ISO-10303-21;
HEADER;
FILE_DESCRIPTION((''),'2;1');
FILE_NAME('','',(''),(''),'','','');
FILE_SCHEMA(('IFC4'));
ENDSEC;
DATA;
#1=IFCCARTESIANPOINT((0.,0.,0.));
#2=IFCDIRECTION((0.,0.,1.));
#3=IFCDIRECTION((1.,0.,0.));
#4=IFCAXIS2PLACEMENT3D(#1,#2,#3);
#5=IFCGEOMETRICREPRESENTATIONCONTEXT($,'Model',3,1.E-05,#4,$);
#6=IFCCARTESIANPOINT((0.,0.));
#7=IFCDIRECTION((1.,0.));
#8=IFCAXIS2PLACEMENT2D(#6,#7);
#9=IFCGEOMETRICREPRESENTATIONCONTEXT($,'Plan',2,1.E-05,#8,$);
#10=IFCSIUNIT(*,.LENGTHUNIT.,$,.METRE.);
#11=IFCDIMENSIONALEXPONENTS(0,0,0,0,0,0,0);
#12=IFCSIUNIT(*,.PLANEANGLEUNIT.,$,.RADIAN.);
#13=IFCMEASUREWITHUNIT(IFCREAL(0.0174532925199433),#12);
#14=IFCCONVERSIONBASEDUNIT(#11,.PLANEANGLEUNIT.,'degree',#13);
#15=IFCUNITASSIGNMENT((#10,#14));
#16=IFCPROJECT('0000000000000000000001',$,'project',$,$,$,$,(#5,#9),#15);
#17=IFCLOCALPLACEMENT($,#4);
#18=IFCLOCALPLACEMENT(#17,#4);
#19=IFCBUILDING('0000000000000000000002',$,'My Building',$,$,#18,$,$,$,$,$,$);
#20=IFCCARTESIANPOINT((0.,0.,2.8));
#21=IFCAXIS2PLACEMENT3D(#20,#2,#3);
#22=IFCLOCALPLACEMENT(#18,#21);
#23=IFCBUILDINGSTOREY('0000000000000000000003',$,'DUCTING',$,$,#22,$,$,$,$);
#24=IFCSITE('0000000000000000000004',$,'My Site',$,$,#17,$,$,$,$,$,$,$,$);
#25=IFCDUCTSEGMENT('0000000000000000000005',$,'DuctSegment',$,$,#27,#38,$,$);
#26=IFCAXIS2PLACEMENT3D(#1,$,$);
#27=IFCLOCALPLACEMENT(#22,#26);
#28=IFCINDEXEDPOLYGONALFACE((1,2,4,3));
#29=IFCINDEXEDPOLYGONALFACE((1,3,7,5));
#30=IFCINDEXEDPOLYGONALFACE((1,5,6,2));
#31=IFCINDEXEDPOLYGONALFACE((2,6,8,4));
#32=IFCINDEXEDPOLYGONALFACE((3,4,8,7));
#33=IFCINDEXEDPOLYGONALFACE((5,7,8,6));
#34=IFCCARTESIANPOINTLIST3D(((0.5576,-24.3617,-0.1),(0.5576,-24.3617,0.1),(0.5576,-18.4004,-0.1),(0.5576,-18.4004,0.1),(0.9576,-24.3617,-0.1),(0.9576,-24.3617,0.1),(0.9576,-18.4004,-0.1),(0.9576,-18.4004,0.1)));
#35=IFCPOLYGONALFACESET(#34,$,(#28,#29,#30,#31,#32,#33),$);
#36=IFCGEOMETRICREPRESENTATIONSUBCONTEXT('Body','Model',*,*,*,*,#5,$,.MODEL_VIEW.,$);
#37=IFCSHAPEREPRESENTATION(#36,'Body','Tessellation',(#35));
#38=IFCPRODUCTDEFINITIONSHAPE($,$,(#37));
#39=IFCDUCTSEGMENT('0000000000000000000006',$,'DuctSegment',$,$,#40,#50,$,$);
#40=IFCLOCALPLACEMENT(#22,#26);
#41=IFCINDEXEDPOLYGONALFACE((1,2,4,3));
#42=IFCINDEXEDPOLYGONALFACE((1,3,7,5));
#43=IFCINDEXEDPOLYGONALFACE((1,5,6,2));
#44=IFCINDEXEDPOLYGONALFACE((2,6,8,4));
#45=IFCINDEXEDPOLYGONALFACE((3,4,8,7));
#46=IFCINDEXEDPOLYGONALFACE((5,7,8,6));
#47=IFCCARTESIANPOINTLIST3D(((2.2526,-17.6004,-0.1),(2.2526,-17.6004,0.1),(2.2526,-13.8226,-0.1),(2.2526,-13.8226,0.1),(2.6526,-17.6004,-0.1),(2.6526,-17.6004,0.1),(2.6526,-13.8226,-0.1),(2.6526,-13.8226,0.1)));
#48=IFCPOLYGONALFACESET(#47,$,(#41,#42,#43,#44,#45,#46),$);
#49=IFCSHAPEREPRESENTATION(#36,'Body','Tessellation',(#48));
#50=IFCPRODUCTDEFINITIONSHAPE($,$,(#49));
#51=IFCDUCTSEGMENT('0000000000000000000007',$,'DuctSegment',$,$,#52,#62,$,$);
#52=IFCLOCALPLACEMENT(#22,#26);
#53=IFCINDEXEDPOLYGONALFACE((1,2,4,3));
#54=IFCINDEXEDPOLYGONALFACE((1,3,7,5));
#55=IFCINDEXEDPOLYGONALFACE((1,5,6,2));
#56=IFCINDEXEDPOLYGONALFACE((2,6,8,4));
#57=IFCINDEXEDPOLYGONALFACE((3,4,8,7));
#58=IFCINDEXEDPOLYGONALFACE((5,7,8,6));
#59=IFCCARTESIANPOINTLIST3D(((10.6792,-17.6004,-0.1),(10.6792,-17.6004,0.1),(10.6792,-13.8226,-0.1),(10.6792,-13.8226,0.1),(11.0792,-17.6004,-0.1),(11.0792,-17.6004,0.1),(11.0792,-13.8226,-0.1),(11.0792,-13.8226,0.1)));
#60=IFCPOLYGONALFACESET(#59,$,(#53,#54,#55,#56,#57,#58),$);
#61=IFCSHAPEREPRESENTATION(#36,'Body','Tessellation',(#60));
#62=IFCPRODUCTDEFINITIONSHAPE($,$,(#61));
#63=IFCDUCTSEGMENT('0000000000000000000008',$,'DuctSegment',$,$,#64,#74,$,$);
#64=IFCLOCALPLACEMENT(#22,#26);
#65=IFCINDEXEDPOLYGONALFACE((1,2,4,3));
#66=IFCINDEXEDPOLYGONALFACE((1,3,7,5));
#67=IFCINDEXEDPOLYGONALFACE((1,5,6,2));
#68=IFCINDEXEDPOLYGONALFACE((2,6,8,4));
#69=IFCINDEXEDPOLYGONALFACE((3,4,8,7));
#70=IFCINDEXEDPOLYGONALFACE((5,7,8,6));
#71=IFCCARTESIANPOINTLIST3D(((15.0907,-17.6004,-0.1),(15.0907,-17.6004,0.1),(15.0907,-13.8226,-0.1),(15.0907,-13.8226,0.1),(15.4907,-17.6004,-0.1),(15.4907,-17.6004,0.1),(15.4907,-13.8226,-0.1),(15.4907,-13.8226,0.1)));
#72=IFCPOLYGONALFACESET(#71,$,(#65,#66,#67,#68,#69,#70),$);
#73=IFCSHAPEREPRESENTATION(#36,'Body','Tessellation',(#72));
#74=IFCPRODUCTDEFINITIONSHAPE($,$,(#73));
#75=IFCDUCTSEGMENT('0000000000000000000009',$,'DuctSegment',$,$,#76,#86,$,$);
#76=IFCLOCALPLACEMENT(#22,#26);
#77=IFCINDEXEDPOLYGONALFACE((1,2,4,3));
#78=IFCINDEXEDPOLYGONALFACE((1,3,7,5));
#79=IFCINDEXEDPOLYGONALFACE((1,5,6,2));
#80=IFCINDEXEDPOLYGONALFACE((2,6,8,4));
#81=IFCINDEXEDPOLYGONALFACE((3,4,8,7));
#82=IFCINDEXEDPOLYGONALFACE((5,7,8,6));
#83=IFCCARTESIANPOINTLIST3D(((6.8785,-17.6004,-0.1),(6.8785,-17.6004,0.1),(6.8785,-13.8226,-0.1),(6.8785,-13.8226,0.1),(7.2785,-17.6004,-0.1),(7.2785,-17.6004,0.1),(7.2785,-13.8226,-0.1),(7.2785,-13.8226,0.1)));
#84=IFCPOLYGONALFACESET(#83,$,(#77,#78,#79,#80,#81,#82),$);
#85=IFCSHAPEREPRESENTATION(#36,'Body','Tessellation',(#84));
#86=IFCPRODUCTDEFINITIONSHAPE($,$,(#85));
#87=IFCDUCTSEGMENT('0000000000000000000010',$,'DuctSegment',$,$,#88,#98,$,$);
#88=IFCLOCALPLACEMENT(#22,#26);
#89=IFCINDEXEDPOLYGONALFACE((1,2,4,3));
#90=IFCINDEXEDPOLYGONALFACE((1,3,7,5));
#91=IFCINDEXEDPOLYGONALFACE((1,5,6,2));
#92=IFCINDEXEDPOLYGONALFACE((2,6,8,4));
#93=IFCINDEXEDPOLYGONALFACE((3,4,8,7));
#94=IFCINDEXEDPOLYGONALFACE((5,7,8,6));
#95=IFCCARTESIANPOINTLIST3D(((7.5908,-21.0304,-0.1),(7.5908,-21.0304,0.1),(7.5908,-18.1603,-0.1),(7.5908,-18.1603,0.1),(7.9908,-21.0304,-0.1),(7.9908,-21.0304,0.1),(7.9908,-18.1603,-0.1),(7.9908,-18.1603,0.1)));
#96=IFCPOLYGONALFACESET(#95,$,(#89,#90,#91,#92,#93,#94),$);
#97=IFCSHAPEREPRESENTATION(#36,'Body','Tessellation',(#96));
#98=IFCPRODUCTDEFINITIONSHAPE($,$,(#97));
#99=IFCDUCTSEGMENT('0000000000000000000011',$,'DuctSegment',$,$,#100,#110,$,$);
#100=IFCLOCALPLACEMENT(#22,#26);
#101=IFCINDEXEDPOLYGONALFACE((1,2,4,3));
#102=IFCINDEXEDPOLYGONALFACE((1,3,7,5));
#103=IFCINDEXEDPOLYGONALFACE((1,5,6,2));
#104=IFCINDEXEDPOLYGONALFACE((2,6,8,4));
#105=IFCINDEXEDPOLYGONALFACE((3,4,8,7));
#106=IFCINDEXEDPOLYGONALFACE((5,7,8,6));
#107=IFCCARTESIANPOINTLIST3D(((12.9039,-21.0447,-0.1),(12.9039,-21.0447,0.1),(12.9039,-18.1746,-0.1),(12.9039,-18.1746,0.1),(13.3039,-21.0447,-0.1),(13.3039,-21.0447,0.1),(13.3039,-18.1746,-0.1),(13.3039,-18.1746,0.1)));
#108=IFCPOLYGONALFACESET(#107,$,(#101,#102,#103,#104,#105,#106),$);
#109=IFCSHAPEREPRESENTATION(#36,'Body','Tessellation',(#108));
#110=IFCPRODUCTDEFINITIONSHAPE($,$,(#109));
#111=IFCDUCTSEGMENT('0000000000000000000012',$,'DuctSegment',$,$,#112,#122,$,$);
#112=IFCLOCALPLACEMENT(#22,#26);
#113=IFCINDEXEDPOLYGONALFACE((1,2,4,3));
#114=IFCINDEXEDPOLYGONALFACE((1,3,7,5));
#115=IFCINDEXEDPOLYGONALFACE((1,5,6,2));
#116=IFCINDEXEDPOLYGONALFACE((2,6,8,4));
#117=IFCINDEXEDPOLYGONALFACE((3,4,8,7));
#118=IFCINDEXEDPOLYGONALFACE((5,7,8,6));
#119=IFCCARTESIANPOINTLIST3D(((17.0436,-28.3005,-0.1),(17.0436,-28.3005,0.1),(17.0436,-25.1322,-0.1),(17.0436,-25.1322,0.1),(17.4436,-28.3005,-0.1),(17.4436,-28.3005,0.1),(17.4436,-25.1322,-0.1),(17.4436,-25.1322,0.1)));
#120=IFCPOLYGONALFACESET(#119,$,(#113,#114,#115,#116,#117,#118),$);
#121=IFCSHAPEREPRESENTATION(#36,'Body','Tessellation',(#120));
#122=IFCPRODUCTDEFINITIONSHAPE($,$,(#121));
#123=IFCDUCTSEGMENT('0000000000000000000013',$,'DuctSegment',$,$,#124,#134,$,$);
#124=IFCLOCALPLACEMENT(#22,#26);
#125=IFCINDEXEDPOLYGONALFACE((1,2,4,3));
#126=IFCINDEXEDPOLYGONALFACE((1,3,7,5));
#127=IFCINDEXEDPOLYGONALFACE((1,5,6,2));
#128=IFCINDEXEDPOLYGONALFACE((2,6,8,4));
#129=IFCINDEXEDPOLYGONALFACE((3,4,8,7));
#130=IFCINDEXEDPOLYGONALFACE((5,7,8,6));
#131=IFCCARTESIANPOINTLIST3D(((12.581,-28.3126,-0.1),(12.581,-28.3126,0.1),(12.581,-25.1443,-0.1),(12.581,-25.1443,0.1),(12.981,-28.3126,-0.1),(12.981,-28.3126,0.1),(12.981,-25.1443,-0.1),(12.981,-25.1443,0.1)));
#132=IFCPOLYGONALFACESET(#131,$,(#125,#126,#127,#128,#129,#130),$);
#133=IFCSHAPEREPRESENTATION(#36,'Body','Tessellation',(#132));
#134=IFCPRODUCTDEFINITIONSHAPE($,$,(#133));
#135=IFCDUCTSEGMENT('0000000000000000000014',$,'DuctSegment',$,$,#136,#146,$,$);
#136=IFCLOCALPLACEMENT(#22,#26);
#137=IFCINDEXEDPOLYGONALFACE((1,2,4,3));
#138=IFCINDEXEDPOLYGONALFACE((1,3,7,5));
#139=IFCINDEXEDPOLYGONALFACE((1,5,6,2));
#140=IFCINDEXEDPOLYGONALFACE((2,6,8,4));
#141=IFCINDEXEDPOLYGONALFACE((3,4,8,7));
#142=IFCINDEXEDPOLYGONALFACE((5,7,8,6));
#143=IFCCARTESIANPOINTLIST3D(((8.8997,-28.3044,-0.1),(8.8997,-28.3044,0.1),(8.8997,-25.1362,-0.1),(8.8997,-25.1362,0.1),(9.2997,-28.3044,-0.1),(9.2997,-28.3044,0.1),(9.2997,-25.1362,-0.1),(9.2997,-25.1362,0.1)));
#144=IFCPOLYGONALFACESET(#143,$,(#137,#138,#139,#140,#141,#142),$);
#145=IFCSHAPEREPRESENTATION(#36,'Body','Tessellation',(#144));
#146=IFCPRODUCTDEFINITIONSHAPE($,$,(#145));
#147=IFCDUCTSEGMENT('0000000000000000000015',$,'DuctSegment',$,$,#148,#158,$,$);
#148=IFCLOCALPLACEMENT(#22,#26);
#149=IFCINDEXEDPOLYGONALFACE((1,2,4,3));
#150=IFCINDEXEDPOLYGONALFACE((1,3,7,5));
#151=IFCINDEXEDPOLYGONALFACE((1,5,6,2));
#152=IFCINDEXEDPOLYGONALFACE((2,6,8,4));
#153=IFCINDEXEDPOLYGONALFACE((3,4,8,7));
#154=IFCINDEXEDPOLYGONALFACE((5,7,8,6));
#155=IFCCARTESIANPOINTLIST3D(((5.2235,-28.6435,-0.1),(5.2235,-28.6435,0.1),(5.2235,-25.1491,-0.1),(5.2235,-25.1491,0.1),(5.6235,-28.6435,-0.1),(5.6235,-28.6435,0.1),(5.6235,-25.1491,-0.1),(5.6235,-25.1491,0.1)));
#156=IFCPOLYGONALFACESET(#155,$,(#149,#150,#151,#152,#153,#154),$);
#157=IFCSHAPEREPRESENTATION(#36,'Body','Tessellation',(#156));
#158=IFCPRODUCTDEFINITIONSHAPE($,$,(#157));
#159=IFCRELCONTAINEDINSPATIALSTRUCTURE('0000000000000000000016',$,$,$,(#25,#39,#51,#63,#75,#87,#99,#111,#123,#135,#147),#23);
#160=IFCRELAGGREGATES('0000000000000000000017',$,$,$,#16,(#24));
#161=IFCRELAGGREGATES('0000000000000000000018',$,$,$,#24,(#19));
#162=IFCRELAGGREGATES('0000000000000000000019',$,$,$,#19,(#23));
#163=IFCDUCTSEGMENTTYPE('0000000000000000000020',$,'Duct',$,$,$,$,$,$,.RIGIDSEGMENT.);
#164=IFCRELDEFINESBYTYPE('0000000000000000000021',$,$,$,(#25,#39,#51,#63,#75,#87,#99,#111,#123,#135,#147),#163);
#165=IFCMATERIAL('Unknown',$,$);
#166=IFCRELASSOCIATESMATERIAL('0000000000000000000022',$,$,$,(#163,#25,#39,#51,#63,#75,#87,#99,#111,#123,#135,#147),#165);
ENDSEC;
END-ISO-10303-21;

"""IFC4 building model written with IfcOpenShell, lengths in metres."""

from ifc_helpers import new_model, entity, si_unit, converted_unit, frame, origin_with_axes, origin_2d_with_axis, place, context, subcontext, project, spatial, rectangle, extrude, material, material_profile, profile_set, profile_usage, type_object, element, save


model = new_model("IFC4")

# Units and contexts
model_context = context("Model", 3, precision=1e-05, world=origin_with_axes())
plan_context = context("Plan", 2, precision=1e-05, world=origin_2d_with_axis())
body_context = subcontext(model_context, "Body", "Model", "MODEL_VIEW")
ifc_project = project(units=[si_unit("LENGTHUNIT", "METRE"), converted_unit("PLANEANGLEUNIT", "degree", entity("IfcReal", 0.0174532925199433), si_unit("PLANEANGLEUNIT", "RADIAN"), dimensions=[0, 0, 0, 0, 0, 0, 0])], contexts=[model_context, plan_context])

# Site, building, storey
site_placement = place(None, origin_with_axes())
site = spatial("IfcSite", under=ifc_project, at=site_placement, Name="My Site")
building_placement = place(site_placement, origin_with_axes())
building = spatial("IfcBuilding", under=site, at=building_placement, Name="My Building")
storey_placement = place(building_placement, frame((0.0, 0.0, 2.8), z_axis=(0.0, 0.0, 1.0), x_axis=(1.0, 0.0, 0.0)))
storey = spatial("IfcBuildingStorey", under=building, at=storey_placement, Name="DUCTING")

# Duct segments
ifc_material = material(Name="Unknown")
ifc_material_profile_1 = material_profile(ifc_material, rectangle(XDim=0.4, YDim=0.2))
ifc_profile_set_1 = profile_set([ifc_material_profile_1])
ifc_profile_usage_1 = profile_usage(ifc_profile_set_1, cardinal=5)
duct_segment_type = type_object("IfcDuctSegmentType", Name="Duct", PredefinedType="RIGIDSEGMENT", material=ifc_profile_set_1)
duct_segment_1_placement = place(storey_placement, frame((0.7576, -24.3617, 0.0), z_axis=(0.0, 1.0, 0.0), x_axis=(-1.0, 0.0, 0.0)))
element("IfcDuctSegment", 1, at=duct_segment_1_placement, inside=storey, type_object=duct_segment_type, material=ifc_profile_usage_1, Name="DuctSegment", context=body_context, shape_type="SweptSolid", body=[
    extrude(rectangle(XDim=0.4, YDim=0.2), origin_with_axes(), (0.0, 0.0, 1.0), 5.9613),
])
ifc_profile_usage_2 = profile_usage(ifc_profile_set_1, cardinal=5)
duct_segment_2_placement = place(storey_placement, frame((2.4526, -17.6004, 0.0), z_axis=(0.0, 1.0, 0.0), x_axis=(-1.0, 0.0, 0.0)))
element("IfcDuctSegment", 2, at=duct_segment_2_placement, inside=storey, type_object=duct_segment_type, material=ifc_profile_usage_2, Name="DuctSegment", context=body_context, shape_type="SweptSolid", body=[
    extrude(rectangle(XDim=0.4, YDim=0.2), origin_with_axes(), (0.0, 0.0, 1.0), 3.7777),
])
ifc_profile_usage_3 = profile_usage(ifc_profile_set_1, cardinal=5)
duct_segment_3_placement = place(storey_placement, frame((10.8792, -17.6004, 0.0), z_axis=(0.0, 1.0, 0.0), x_axis=(-1.0, 0.0, 0.0)))
element("IfcDuctSegment", 3, at=duct_segment_3_placement, inside=storey, type_object=duct_segment_type, material=ifc_profile_usage_3, Name="DuctSegment", context=body_context, shape_type="SweptSolid", body=[
    extrude(rectangle(XDim=0.4, YDim=0.2), origin_with_axes(), (0.0, 0.0, 1.0), 3.7777),
])
ifc_profile_usage_4 = profile_usage(ifc_profile_set_1, cardinal=5)
duct_segment_4_placement = place(storey_placement, frame((15.2907, -17.6004, 0.0), z_axis=(0.0, 1.0, 0.0), x_axis=(-1.0, 0.0, 0.0)))
element("IfcDuctSegment", 4, at=duct_segment_4_placement, inside=storey, type_object=duct_segment_type, material=ifc_profile_usage_4, Name="DuctSegment", context=body_context, shape_type="SweptSolid", body=[
    extrude(rectangle(XDim=0.4, YDim=0.2), origin_with_axes(), (0.0, 0.0, 1.0), 3.7777),
])
ifc_profile_usage_5 = profile_usage(ifc_profile_set_1, cardinal=5)
duct_segment_5_placement = place(storey_placement, frame((7.0785, -13.8226, 0.0), z_axis=(0.0, -1.0, 0.0), x_axis=(1.0, 0.0, 0.0)))
element("IfcDuctSegment", 5, at=duct_segment_5_placement, inside=storey, type_object=duct_segment_type, material=ifc_profile_usage_5, Name="DuctSegment", context=body_context, shape_type="SweptSolid", body=[
    extrude(rectangle(XDim=0.4, YDim=0.2), origin_with_axes(), (0.0, 0.0, 1.0), 3.7777),
])
ifc_profile_usage_6 = profile_usage(ifc_profile_set_1, cardinal=5)
duct_segment_6_placement = place(storey_placement, frame((7.7908, -21.0304, 0.0), z_axis=(-0.000001, 1.0, 0.0), x_axis=(-1.0, -0.000001, 0.0)))
element("IfcDuctSegment", 6, at=duct_segment_6_placement, inside=storey, type_object=duct_segment_type, material=ifc_profile_usage_6, Name="DuctSegment", context=body_context, shape_type="SweptSolid", body=[
    extrude(rectangle(XDim=0.4, YDim=0.2), origin_with_axes(), (0.0, 0.0, 1.0), 2.8701),
])
ifc_profile_usage_7 = profile_usage(ifc_profile_set_1, cardinal=5)
duct_segment_7_placement = place(storey_placement, frame((13.1039, -21.0447, 0.0), z_axis=(-0.000001, 1.0, 0.0), x_axis=(-1.0, -0.000001, 0.0)))
element("IfcDuctSegment", 7, at=duct_segment_7_placement, inside=storey, type_object=duct_segment_type, material=ifc_profile_usage_7, Name="DuctSegment", context=body_context, shape_type="SweptSolid", body=[
    extrude(rectangle(XDim=0.4, YDim=0.2), origin_with_axes(), (0.0, 0.0, 1.0), 2.8701),
])
ifc_profile_usage_8 = profile_usage(ifc_profile_set_1, cardinal=5)
duct_segment_8_placement = place(storey_placement, frame((17.2436, -28.3005, 0.0), z_axis=(0.0, 1.0, 0.0), x_axis=(-1.0, 0.0, 0.0)))
element("IfcDuctSegment", 8, at=duct_segment_8_placement, inside=storey, type_object=duct_segment_type, material=ifc_profile_usage_8, Name="DuctSegment", context=body_context, shape_type="SweptSolid", body=[
    extrude(rectangle(XDim=0.4, YDim=0.2), origin_with_axes(), (0.0, 0.0, 1.0), 3.1683),
])
ifc_profile_usage_9 = profile_usage(ifc_profile_set_1, cardinal=5)
duct_segment_9_placement = place(storey_placement, frame((12.781, -28.3126, 0.0), z_axis=(0.0, 1.0, 0.0), x_axis=(-1.0, 0.0, 0.0)))
element("IfcDuctSegment", 9, at=duct_segment_9_placement, inside=storey, type_object=duct_segment_type, material=ifc_profile_usage_9, Name="DuctSegment", context=body_context, shape_type="SweptSolid", body=[
    extrude(rectangle(XDim=0.4, YDim=0.2), origin_with_axes(), (0.0, 0.0, 1.0), 3.1683),
])
ifc_profile_usage_10 = profile_usage(ifc_profile_set_1, cardinal=5)
duct_segment_10_placement = place(storey_placement, frame((9.0997, -28.3044, 0.0), z_axis=(0.0, 1.0, 0.0), x_axis=(-1.0, 0.0, 0.0)))
element("IfcDuctSegment", 10, at=duct_segment_10_placement, inside=storey, type_object=duct_segment_type, material=ifc_profile_usage_10, Name="DuctSegment", context=body_context, shape_type="SweptSolid", body=[
    extrude(rectangle(XDim=0.4, YDim=0.2), origin_with_axes(), (0.0, 0.0, 1.0), 3.1683),
])
ifc_profile_usage_11 = profile_usage(ifc_profile_set_1, cardinal=5)
duct_segment_11_placement = place(storey_placement, frame((5.4235, -25.1491, 0.0), z_axis=(0.0, -1.0, 0.0), x_axis=(1.0, 0.0, 0.0)))
element("IfcDuctSegment", 11, at=duct_segment_11_placement, inside=storey, type_object=duct_segment_type, material=ifc_profile_usage_11, Name="DuctSegment", context=body_context, shape_type="SweptSolid", body=[
    extrude(rectangle(XDim=0.4, YDim=0.2), origin_with_axes(), (0.0, 0.0, 1.0), 3.4944),
])

save(model, "model.ifc")
